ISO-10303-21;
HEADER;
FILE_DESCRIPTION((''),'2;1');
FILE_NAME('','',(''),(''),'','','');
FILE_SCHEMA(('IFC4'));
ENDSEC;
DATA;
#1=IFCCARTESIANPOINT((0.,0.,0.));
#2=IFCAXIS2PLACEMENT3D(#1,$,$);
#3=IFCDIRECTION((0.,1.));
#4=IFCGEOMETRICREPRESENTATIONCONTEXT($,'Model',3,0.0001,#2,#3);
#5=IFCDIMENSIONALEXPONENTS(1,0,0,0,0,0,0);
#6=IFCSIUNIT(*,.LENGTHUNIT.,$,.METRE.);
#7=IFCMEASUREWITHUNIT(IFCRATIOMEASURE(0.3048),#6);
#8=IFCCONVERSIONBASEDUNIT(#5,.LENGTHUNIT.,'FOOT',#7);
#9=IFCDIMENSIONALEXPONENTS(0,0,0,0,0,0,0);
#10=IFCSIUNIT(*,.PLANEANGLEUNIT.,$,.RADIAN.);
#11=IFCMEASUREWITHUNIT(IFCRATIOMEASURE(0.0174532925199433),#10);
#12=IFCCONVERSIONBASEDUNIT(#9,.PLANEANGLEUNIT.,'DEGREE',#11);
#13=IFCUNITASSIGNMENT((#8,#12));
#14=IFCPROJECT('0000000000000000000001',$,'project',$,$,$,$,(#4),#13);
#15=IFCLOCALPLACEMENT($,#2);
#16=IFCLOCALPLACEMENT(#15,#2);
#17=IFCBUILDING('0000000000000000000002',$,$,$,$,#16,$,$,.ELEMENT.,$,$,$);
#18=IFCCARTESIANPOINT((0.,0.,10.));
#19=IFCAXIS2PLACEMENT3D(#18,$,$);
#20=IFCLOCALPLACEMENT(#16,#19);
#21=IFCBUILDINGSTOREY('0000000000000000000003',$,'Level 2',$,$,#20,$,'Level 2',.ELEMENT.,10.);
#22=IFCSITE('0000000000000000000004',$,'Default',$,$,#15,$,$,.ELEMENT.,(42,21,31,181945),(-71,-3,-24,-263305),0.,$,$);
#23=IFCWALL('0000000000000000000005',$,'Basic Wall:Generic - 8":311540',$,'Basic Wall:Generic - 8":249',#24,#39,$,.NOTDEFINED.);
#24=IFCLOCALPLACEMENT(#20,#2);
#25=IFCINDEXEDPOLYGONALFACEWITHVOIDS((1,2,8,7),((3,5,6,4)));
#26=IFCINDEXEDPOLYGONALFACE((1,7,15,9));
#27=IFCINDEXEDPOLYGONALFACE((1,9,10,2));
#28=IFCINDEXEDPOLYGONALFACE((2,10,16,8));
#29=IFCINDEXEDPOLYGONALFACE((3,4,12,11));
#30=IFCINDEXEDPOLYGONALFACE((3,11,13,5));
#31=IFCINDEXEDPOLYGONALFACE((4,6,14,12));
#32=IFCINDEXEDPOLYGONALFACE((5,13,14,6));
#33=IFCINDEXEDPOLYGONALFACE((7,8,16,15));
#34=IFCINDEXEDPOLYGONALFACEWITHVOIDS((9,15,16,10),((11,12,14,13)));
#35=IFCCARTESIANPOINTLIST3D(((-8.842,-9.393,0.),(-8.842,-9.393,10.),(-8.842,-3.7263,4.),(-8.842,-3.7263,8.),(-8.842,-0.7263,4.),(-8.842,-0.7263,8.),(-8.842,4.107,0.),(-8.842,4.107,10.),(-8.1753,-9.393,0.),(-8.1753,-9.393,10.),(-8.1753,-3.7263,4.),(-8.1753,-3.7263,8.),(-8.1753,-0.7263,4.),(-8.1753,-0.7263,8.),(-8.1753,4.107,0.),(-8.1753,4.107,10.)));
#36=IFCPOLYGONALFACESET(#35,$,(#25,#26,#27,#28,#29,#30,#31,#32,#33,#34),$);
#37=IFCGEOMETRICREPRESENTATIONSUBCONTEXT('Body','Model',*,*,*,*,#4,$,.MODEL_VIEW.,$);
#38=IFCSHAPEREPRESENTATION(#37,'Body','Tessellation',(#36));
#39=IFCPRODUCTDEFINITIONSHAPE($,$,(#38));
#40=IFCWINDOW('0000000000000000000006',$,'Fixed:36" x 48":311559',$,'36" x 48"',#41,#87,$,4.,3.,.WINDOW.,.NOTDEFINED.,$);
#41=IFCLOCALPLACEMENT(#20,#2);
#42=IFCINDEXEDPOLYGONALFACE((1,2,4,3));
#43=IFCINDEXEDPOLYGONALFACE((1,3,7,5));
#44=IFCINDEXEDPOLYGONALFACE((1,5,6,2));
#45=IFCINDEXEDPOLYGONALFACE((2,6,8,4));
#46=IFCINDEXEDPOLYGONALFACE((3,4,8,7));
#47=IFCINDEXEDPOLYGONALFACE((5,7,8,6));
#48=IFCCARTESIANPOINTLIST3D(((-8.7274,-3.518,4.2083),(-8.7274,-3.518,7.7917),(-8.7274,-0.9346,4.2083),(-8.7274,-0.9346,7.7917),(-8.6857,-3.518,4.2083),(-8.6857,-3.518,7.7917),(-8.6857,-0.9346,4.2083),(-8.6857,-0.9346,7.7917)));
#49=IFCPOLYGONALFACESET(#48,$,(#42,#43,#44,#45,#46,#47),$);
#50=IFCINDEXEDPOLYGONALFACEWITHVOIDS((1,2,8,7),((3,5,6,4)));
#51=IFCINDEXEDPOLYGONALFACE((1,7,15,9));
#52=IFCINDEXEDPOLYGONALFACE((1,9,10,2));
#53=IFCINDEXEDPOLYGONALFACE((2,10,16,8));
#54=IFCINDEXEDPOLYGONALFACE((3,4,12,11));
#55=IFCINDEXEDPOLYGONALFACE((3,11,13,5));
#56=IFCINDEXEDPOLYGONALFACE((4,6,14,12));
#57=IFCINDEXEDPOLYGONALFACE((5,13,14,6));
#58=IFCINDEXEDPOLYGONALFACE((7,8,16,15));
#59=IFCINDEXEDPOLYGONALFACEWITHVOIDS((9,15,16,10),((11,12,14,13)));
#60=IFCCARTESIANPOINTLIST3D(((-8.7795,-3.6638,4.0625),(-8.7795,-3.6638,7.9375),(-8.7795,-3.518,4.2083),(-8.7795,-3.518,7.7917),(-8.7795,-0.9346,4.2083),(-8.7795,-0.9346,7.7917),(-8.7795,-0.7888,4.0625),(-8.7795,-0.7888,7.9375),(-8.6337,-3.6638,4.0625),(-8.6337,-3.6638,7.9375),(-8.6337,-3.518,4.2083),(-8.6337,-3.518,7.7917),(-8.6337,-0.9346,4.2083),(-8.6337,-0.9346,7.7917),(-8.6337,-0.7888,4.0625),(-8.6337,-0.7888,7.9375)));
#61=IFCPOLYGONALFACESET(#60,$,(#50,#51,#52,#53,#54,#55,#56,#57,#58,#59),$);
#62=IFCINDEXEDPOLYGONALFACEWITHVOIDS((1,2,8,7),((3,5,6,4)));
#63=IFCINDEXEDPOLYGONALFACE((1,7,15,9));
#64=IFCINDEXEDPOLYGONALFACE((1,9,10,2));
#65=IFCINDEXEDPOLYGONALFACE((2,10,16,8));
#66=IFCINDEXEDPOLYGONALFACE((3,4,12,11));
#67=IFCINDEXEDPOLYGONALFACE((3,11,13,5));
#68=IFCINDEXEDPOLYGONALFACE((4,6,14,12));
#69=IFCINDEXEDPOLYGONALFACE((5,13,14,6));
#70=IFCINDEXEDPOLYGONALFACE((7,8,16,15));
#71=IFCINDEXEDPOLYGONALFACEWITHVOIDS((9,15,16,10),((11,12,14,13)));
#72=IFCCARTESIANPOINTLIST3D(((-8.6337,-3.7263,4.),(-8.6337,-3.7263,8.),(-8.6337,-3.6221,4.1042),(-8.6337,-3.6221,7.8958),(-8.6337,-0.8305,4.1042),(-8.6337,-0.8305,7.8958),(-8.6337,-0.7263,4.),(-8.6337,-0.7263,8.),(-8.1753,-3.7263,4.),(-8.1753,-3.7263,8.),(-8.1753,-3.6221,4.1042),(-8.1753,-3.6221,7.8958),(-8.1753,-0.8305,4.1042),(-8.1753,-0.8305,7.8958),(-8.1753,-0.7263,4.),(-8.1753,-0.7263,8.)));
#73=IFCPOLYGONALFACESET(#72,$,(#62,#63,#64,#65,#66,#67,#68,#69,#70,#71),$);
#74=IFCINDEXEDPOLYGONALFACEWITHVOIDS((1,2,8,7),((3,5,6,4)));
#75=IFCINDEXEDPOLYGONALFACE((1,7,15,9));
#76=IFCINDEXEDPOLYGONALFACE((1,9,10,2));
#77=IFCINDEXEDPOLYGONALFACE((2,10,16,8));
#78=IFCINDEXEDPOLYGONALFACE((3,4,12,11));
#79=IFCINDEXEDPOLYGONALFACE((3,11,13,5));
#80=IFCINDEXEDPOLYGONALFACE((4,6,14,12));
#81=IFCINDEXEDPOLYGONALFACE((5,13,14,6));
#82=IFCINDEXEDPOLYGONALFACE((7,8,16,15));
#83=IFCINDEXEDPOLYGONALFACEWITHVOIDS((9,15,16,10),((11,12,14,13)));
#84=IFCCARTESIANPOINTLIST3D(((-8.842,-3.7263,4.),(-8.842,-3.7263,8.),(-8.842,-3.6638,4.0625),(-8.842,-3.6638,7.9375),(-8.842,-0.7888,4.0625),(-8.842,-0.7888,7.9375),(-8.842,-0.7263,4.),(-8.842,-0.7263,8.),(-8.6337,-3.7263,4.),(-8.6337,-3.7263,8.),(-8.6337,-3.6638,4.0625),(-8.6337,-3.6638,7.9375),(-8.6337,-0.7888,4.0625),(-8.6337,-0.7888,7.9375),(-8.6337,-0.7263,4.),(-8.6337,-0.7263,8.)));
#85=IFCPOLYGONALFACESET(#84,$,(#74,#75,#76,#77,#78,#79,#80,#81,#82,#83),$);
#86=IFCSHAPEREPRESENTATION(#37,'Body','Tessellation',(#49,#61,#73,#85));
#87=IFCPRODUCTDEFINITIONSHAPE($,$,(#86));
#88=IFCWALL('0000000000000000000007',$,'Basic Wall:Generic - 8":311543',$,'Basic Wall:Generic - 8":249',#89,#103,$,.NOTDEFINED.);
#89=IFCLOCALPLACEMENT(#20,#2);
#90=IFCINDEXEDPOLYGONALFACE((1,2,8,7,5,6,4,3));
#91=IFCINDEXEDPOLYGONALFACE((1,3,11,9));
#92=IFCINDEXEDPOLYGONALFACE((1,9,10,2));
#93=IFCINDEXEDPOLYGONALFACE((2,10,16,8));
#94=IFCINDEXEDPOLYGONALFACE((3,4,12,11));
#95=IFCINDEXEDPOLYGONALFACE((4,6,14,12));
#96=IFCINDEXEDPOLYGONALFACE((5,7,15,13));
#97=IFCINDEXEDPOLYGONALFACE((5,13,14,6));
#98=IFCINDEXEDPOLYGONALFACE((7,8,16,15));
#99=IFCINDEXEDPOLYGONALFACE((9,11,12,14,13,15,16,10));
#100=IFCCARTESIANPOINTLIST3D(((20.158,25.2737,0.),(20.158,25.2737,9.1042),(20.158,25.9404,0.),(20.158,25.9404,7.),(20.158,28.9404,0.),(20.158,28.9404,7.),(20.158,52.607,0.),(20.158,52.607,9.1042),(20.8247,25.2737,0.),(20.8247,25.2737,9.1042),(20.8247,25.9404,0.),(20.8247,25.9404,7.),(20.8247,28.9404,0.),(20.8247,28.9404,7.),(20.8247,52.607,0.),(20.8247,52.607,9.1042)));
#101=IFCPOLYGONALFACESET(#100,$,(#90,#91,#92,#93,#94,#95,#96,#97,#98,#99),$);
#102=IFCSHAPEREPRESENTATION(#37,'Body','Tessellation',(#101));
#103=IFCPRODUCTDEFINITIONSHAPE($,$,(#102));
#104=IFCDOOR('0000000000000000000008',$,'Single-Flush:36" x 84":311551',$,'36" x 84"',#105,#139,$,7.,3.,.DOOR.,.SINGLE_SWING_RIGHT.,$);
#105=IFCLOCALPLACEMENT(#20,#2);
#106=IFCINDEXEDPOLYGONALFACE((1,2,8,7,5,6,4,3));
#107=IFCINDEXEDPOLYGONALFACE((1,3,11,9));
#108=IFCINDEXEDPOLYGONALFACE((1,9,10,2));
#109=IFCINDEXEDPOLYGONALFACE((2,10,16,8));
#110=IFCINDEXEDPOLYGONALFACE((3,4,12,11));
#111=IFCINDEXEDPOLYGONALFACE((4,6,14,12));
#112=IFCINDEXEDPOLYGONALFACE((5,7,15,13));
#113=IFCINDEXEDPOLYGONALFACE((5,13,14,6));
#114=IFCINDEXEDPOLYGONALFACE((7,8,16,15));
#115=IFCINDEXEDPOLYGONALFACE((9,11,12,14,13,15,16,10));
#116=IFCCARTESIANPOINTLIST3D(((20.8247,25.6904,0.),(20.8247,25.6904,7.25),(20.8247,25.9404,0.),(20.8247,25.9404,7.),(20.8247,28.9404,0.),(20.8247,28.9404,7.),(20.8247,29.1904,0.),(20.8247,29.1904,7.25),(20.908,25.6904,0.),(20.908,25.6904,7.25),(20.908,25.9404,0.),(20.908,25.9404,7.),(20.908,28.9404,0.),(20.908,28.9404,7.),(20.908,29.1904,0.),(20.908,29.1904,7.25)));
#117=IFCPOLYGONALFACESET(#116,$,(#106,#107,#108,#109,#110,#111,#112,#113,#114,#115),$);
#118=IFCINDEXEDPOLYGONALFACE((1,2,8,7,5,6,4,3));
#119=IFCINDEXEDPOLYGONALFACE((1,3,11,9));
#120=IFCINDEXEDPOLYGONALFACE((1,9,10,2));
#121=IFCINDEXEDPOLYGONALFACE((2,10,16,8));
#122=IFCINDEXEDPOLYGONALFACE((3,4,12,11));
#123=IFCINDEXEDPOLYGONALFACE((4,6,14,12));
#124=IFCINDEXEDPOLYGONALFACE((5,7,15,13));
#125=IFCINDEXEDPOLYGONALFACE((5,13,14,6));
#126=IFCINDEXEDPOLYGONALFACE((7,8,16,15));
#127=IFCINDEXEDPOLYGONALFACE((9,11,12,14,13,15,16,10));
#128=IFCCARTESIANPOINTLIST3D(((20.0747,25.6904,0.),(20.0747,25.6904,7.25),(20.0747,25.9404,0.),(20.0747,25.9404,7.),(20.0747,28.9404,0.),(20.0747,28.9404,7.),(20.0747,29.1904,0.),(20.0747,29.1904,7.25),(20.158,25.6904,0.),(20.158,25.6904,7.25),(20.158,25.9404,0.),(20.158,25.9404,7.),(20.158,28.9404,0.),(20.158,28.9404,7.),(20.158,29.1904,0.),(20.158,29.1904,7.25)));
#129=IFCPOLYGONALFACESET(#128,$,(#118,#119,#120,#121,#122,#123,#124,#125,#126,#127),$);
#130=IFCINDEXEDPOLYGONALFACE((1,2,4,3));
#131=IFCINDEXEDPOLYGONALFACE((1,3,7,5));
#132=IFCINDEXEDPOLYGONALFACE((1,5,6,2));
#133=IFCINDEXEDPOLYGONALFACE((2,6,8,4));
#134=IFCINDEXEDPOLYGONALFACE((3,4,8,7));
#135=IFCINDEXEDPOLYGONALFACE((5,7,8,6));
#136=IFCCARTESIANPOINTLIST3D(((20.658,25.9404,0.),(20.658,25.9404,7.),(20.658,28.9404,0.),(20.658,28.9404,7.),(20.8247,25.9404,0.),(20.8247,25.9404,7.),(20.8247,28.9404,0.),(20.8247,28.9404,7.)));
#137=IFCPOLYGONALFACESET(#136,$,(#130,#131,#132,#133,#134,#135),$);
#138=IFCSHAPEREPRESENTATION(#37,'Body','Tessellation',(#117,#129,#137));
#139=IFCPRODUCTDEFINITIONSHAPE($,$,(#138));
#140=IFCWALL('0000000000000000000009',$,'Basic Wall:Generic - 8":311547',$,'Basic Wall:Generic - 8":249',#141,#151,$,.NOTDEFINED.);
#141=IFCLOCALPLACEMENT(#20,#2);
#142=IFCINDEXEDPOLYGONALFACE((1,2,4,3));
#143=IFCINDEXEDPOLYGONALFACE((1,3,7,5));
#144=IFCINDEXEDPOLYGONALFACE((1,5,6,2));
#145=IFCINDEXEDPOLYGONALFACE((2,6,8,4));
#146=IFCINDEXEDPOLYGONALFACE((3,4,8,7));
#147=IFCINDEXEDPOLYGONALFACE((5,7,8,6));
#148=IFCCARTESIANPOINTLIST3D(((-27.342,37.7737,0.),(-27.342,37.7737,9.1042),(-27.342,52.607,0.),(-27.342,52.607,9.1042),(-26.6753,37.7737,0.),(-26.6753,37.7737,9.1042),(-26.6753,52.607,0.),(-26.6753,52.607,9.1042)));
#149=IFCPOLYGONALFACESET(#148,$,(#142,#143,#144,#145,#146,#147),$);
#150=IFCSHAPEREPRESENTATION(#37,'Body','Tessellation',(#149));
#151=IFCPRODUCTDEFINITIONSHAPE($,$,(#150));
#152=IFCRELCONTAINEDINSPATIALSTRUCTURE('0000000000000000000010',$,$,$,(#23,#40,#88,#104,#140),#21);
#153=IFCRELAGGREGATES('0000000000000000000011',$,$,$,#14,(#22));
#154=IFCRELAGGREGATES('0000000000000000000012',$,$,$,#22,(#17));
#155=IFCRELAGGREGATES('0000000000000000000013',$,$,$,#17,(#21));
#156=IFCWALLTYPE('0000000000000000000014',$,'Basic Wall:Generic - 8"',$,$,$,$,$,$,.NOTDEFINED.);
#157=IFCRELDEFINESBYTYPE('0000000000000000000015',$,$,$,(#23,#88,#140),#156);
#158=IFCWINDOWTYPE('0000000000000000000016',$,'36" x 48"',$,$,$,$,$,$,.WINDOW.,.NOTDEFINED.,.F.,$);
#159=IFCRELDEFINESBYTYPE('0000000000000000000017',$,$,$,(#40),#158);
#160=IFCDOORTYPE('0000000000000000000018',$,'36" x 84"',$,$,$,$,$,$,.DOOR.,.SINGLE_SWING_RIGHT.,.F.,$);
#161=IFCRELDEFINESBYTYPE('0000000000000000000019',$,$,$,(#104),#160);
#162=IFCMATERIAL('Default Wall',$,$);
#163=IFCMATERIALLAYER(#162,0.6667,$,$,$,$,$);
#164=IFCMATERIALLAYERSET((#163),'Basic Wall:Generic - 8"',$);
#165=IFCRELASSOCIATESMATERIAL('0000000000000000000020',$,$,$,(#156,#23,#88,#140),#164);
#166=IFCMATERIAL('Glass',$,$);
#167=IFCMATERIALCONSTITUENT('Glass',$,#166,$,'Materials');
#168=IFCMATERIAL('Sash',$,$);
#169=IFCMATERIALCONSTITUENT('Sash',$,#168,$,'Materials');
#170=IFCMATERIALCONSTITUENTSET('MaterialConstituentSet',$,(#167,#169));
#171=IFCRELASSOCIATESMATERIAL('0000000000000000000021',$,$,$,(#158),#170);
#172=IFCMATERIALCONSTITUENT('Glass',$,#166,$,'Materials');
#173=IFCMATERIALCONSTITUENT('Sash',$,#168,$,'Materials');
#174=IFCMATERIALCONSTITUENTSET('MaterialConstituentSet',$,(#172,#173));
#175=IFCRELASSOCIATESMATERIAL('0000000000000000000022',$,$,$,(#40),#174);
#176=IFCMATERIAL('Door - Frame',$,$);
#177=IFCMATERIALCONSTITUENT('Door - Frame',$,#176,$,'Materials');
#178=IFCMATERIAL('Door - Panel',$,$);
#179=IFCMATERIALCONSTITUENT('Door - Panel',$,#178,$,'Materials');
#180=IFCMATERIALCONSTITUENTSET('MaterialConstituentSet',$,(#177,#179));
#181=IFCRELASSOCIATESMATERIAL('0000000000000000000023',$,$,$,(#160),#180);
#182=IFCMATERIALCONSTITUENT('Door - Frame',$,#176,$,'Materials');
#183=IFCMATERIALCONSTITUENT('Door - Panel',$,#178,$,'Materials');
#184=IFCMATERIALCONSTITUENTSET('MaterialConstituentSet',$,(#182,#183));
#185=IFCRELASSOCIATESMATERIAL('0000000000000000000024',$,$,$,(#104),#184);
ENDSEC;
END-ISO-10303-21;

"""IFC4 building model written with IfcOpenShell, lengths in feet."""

from ifc_helpers import new_model, entity, si_unit, converted_unit, direction, frame, frame_2d, origin, place, context, subcontext, project, spatial, polyline, rectangle, outline, extrude, clip, bounded_halfspace, source, transform, mapped, material, layer, layer_set, layer_usage, constituent, constituent_set, type_object, type_shapes, element, fill, save


model = new_model("IFC4")

# Units and contexts
model_context = context("Model", 3, precision=0.0001, world=origin(), true_north=direction((0.0, 1.0)))
body_context = subcontext(model_context, "Body", "Model", "MODEL_VIEW")
ifc_project = project(units=[converted_unit("LENGTHUNIT", "FOOT", entity("IfcRatioMeasure", 0.3048), si_unit("LENGTHUNIT", "METRE"), dimensions=[1, 0, 0, 0, 0, 0, 0]), converted_unit("PLANEANGLEUNIT", "DEGREE", entity("IfcRatioMeasure", 0.0174532925199433), si_unit("PLANEANGLEUNIT", "RADIAN"), dimensions=[0, 0, 0, 0, 0, 0, 0])], contexts=[model_context])

# Site, building, storey
site_placement = place(None, origin())
site = spatial("IfcSite", under=ifc_project, at=site_placement, Name="Default", CompositionType="ELEMENT", RefLatitude=(42, 21, 31, 181945), RefLongitude=(-71, -3, -24, -263305), RefElevation=0.0)
building_placement = place(site_placement, origin())
building = spatial("IfcBuilding", under=site, at=building_placement, CompositionType="ELEMENT")
storey_placement = place(building_placement, frame((0.0, 0.0, 10.0)))
storey = spatial("IfcBuildingStorey", under=building, at=storey_placement, Name="Level 2", LongName="Level 2", CompositionType="ELEMENT", Elevation=10.0)

# Shared definitions
ifc_material_1 = material(Name="Default Wall")
ifc_layer_1 = layer(ifc_material_1, 0.6667)
ifc_layer_set_1 = layer_set([ifc_layer_1], Name="Basic Wall:Generic - 8\"")
wall_type = type_object("IfcWallType", Name="Basic Wall:Generic - 8\"", PredefinedType="NOTDEFINED", material=ifc_layer_set_1)
ifc_material_2 = material(Name="Glass")
ifc_material_3 = material(Name="Sash")
ifc_constituent_1 = constituent(ifc_material_2, Name="Glass", Category="Materials")
ifc_constituent_2 = constituent(ifc_material_3, Name="Sash", Category="Materials")
ifc_constituent_set_1 = constituent_set(constituents=[ifc_constituent_1, ifc_constituent_2], Name="MaterialConstituentSet")
window_type_1 = type_object("IfcWindowType", Name="36\" x 48\"", ParameterTakesPrecedence=False, PartitioningType="NOTDEFINED", PredefinedType="WINDOW", material=ifc_constituent_set_1)
shared_shape_1 = source(origin(), body_context, "Body", "SweptSolid", [
    extrude(rectangle(XDim=0.0417, YDim=2.5833, at=frame_2d((0.0, 0.0), x_axis=(1.0, 0.0))), frame((1.5, 0.5312, 0.2083), z_axis=(0.0, 0.0, 1.0), x_axis=(0.0, 1.0, 0.0)), (0.0, 0.0, 1.0), 3.5833),
    extrude(outline(polyline([(-1.4375, -1.9375), (1.4375, -1.9375), (1.4375, 1.9375), (-1.4375, 1.9375), (-1.4375, -1.9375)]), holes=[polyline([(-1.2917, -1.7917), (-1.2917, 1.7917), (1.2917, 1.7917), (1.2917, -1.7917), (-1.2917, -1.7917)])]), frame((1.5, 0.4583, 2.0), z_axis=(0.0, 1.0, 0.0), x_axis=(1.0, 0.0, 0.0)), (0.0, 0.0, 1.0), 0.1458),
    extrude(outline(polyline([(-1.5, -2.0), (1.5, -2.0), (1.5, 2.0), (-1.5, 2.0), (-1.5, -2.0)]), holes=[polyline([(-1.3958, -1.8958), (-1.3958, 1.8958), (1.3958, 1.8958), (1.3958, -1.8958), (-1.3958, -1.8958)])]), frame((1.5, 0.0, 2.0), z_axis=(0.0, 1.0, 0.0), x_axis=(1.0, 0.0, 0.0)), (0.0, 0.0, 1.0), 0.4583),
    extrude(outline(polyline([(-2.0, -1.5), (2.0, -1.5), (2.0, 1.5), (-2.0, 1.5), (-2.0, -1.5)]), holes=[polyline([(-1.9375, -1.4375), (-1.9375, 1.4375), (1.9375, 1.4375), (1.9375, -1.4375), (-1.9375, -1.4375)])]), frame((1.5, 0.4583, 2.0), z_axis=(0.0, 1.0, 0.0), x_axis=(0.0, 0.0, -1.0)), (0.0, 0.0, 1.0), 0.2083),
])
type_shapes(window_type_1, [shared_shape_1])

# Shared definitions
ifc_material_4 = material(Name="Door - Frame")
ifc_material_5 = material(Name="Door - Panel")

# Wall, opening, window
ifc_layer_usage_1 = layer_usage(ifc_layer_set_1, "AXIS2", "NEGATIVE", 0.3333)
wall_1_placement = place(storey_placement, frame((-8.5087, -9.393, 0.0), z_axis=(0.0, 0.0, 1.0), x_axis=(0.0, 1.0, 0.0)))
wall_1 = element("IfcWall", 1, at=wall_1_placement, inside=storey, type_object=wall_type, material=ifc_layer_usage_1, Name="Basic Wall:Generic - 8\":311540", ObjectType="Basic Wall:Generic - 8\":249", PredefinedType="NOTDEFINED", context=body_context, shape_type="SweptSolid", body=[
    extrude(rectangle(XDim=13.5, YDim=0.6667, at=frame_2d((6.75, 0.0), x_axis=(-1.0, 0.0))), origin(), (0.0, 0.0, 1.0), 10.0),
])
opening_1_placement = place(wall_1_placement, frame((5.6667, -0.3333, 4.0)))
opening_1 = element("IfcOpeningElement", 2, at=opening_1_placement, cuts=wall_1, ObjectType="Opening", PredefinedType="OPENING", context=body_context, shape_type="SweptSolid", body=[
    extrude(rectangle(XDim=4.0, YDim=3.0, at=frame_2d((2.0, 1.5), x_axis=(-1.0, 0.0))), frame((0.0, 0.0, 0.0), z_axis=(0.0, 1.0, 0.0), x_axis=(0.0, 0.0, 1.0)), (0.0, 0.0, 1.0), 0.6667),
])
ifc_constituent_3 = constituent(ifc_material_2, Name="Glass", Category="Materials")
ifc_constituent_4 = constituent(ifc_material_3, Name="Sash", Category="Materials")
ifc_constituent_set_2 = constituent_set(constituents=[ifc_constituent_3, ifc_constituent_4], Name="MaterialConstituentSet")
window_1_placement = place(opening_1_placement, origin())
window_1 = element("IfcWindow", 3, at=window_1_placement, inside=storey, type_object=window_type_1, material=ifc_constituent_set_2, Name="Fixed:36\" x 48\":311559", ObjectType="36\" x 48\"", OverallHeight=4.0, OverallWidth=3.0, PartitioningType="NOTDEFINED", PredefinedType="WINDOW", context=body_context, shape_type="MappedRepresentation", body=[
    mapped(shared_shape_1, transform((0.0, 0.0, 0.0), scale=1.0)),
])
fill(opening_1, window_1)

# Wall, opening, door
ifc_layer_usage_2 = layer_usage(ifc_layer_set_1, "AXIS2", "NEGATIVE", 0.3333)
wall_2_placement = place(storey_placement, frame((20.4913, 52.607, 0.0), z_axis=(0.0, 0.0, 1.0), x_axis=(0.0, -1.0, 0.0)))
wall_2 = element("IfcWall", 4, at=wall_2_placement, inside=storey, type_object=wall_type, material=ifc_layer_usage_2, Name="Basic Wall:Generic - 8\":311543", ObjectType="Basic Wall:Generic - 8\":249", PredefinedType="NOTDEFINED", context=body_context, shape_type="Clipping", body=[
    clip(extrude(rectangle(XDim=27.3333, YDim=0.6667, at=frame_2d((13.6667, 0.0), x_axis=(-1.0, 0.0))), origin(), (0.0, 0.0, 1.0), 9.1042), bounded_halfspace(frame((0.0, -0.3333, 9.1042), z_axis=(0.0, 0.0, -1.0), x_axis=(1.0, 0.0, 0.0)), True, frame((0.0, -0.3333, 9.1042), z_axis=(0.0, 0.0, -1.0), x_axis=(1.0, 0.0, 0.0)), polyline([(0.0, 0.0), (0.0, -0.6667), (27.3333, -0.6667), (27.3333, 0.0), (15.5, 0.0), (14.8333, 0.0), (0.0, 0.0)]))),
])
opening_2_placement = place(wall_2_placement, frame((23.6667, -0.3333, 0.0)))
opening_2 = element("IfcOpeningElement", 5, at=opening_2_placement, cuts=wall_2, ObjectType="Opening", PredefinedType="OPENING", context=body_context, shape_type="SweptSolid", body=[
    extrude(rectangle(XDim=3.0, YDim=7.0, at=frame_2d((3.5, 1.5), x_axis=(0.0, 1.0))), frame((0.0, 0.0, 0.0), z_axis=(0.0, 1.0, 0.0), x_axis=(0.0, 0.0, 1.0)), (0.0, 0.0, 1.0), 0.6667),
])
ifc_constituent_5 = constituent(ifc_material_4, Name="Door - Frame", Category="Materials")
ifc_constituent_6 = constituent(ifc_material_5, Name="Door - Panel", Category="Materials")
ifc_constituent_set_3 = constituent_set(constituents=[ifc_constituent_5, ifc_constituent_6], Name="MaterialConstituentSet")
ifc_constituent_7 = constituent(ifc_material_4, Name="Door - Frame", Category="Materials")
ifc_constituent_8 = constituent(ifc_material_5, Name="Door - Panel", Category="Materials")
ifc_constituent_set_4 = constituent_set(constituents=[ifc_constituent_7, ifc_constituent_8], Name="MaterialConstituentSet")
door_type_1 = type_object("IfcDoorType", Name="36\" x 84\"", OperationType="SINGLE_SWING_RIGHT", ParameterTakesPrecedence=False, PredefinedType="DOOR", material=ifc_constituent_set_4)
shared_shape_2 = source(origin(), body_context, "Body", "SweptSolid", [
    extrude(outline(polyline([(-1.75, -3.6875), (1.75, -3.6875), (1.75, 3.5625), (1.5, 3.5625), (1.5, -3.4375), (-1.5, -3.4375), (-1.5, 3.5625), (-1.75, 3.5625), (-1.75, -3.6875)])), frame((1.5, 0.6667, 3.5625), z_axis=(0.0, 1.0, 0.0), x_axis=(1.0, 0.0, 0.0)), (0.0, 0.0, 1.0), 0.0833),
    extrude(outline(polyline([(-3.6875, -1.75), (3.5625, -1.75), (3.5625, -1.5), (-3.4375, -1.5), (-3.4375, 1.5), (3.5625, 1.5), (3.5625, 1.75), (-3.6875, 1.75), (-3.6875, -1.75)])), frame((1.5, -0.0833, 3.5625), z_axis=(0.0, 1.0, 0.0), x_axis=(0.0, 0.0, -1.0)), (0.0, 0.0, 1.0), 0.0833),
    extrude(rectangle(XDim=0.1667, YDim=3.0, at=frame_2d((0.0, 0.0), x_axis=(1.0, 0.0))), frame((1.5, 0.5833, 0.0), z_axis=(0.0, 0.0, 1.0), x_axis=(0.0, 1.0, 0.0)), (0.0, 0.0, 1.0), 7.0),
])
type_shapes(door_type_1, [shared_shape_2])
door_1_placement = place(opening_2_placement, origin())
door_1 = element("IfcDoor", 6, at=door_1_placement, inside=storey, type_object=door_type_1, material=ifc_constituent_set_3, Name="Single-Flush:36\" x 84\":311551", ObjectType="36\" x 84\"", OperationType="SINGLE_SWING_RIGHT", OverallHeight=7.0, OverallWidth=3.0, PredefinedType="DOOR", context=body_context, shape_type="MappedRepresentation", body=[
    mapped(shared_shape_2, transform((0.0, 0.0, 0.0), scale=1.0)),
])
fill(opening_2, door_1)

# Wall
ifc_layer_usage_3 = layer_usage(ifc_layer_set_1, "AXIS2", "NEGATIVE", 0.3333)
wall_3_placement = place(storey_placement, frame((-27.0087, 37.7737, 0.0), z_axis=(0.0, 0.0, 1.0), x_axis=(0.0, 1.0, 0.0)))
element("IfcWall", 7, at=wall_3_placement, inside=storey, type_object=wall_type, material=ifc_layer_usage_3, Name="Basic Wall:Generic - 8\":311547", ObjectType="Basic Wall:Generic - 8\":249", PredefinedType="NOTDEFINED", context=body_context, shape_type="Clipping", body=[
    clip(extrude(rectangle(XDim=14.8333, YDim=0.6667, at=frame_2d((7.4167, 0.0), x_axis=(-1.0, 0.0))), origin(), (0.0, 0.0, 1.0), 9.1042), bounded_halfspace(frame((0.0, -0.3333, 9.1042), z_axis=(0.0, 0.0, -1.0), x_axis=(-1.0, 0.0, 0.0)), True, frame((0.0, -0.3333, 9.1042), z_axis=(0.0, 0.0, -1.0), x_axis=(-1.0, 0.0, 0.0)), polyline([(0.0, 0.0), (0.0, 0.6667), (-14.8333, 0.6667), (-14.8333, 0.0), (0.0, 0.0)]))),
])

save(model, "model.ifc")
